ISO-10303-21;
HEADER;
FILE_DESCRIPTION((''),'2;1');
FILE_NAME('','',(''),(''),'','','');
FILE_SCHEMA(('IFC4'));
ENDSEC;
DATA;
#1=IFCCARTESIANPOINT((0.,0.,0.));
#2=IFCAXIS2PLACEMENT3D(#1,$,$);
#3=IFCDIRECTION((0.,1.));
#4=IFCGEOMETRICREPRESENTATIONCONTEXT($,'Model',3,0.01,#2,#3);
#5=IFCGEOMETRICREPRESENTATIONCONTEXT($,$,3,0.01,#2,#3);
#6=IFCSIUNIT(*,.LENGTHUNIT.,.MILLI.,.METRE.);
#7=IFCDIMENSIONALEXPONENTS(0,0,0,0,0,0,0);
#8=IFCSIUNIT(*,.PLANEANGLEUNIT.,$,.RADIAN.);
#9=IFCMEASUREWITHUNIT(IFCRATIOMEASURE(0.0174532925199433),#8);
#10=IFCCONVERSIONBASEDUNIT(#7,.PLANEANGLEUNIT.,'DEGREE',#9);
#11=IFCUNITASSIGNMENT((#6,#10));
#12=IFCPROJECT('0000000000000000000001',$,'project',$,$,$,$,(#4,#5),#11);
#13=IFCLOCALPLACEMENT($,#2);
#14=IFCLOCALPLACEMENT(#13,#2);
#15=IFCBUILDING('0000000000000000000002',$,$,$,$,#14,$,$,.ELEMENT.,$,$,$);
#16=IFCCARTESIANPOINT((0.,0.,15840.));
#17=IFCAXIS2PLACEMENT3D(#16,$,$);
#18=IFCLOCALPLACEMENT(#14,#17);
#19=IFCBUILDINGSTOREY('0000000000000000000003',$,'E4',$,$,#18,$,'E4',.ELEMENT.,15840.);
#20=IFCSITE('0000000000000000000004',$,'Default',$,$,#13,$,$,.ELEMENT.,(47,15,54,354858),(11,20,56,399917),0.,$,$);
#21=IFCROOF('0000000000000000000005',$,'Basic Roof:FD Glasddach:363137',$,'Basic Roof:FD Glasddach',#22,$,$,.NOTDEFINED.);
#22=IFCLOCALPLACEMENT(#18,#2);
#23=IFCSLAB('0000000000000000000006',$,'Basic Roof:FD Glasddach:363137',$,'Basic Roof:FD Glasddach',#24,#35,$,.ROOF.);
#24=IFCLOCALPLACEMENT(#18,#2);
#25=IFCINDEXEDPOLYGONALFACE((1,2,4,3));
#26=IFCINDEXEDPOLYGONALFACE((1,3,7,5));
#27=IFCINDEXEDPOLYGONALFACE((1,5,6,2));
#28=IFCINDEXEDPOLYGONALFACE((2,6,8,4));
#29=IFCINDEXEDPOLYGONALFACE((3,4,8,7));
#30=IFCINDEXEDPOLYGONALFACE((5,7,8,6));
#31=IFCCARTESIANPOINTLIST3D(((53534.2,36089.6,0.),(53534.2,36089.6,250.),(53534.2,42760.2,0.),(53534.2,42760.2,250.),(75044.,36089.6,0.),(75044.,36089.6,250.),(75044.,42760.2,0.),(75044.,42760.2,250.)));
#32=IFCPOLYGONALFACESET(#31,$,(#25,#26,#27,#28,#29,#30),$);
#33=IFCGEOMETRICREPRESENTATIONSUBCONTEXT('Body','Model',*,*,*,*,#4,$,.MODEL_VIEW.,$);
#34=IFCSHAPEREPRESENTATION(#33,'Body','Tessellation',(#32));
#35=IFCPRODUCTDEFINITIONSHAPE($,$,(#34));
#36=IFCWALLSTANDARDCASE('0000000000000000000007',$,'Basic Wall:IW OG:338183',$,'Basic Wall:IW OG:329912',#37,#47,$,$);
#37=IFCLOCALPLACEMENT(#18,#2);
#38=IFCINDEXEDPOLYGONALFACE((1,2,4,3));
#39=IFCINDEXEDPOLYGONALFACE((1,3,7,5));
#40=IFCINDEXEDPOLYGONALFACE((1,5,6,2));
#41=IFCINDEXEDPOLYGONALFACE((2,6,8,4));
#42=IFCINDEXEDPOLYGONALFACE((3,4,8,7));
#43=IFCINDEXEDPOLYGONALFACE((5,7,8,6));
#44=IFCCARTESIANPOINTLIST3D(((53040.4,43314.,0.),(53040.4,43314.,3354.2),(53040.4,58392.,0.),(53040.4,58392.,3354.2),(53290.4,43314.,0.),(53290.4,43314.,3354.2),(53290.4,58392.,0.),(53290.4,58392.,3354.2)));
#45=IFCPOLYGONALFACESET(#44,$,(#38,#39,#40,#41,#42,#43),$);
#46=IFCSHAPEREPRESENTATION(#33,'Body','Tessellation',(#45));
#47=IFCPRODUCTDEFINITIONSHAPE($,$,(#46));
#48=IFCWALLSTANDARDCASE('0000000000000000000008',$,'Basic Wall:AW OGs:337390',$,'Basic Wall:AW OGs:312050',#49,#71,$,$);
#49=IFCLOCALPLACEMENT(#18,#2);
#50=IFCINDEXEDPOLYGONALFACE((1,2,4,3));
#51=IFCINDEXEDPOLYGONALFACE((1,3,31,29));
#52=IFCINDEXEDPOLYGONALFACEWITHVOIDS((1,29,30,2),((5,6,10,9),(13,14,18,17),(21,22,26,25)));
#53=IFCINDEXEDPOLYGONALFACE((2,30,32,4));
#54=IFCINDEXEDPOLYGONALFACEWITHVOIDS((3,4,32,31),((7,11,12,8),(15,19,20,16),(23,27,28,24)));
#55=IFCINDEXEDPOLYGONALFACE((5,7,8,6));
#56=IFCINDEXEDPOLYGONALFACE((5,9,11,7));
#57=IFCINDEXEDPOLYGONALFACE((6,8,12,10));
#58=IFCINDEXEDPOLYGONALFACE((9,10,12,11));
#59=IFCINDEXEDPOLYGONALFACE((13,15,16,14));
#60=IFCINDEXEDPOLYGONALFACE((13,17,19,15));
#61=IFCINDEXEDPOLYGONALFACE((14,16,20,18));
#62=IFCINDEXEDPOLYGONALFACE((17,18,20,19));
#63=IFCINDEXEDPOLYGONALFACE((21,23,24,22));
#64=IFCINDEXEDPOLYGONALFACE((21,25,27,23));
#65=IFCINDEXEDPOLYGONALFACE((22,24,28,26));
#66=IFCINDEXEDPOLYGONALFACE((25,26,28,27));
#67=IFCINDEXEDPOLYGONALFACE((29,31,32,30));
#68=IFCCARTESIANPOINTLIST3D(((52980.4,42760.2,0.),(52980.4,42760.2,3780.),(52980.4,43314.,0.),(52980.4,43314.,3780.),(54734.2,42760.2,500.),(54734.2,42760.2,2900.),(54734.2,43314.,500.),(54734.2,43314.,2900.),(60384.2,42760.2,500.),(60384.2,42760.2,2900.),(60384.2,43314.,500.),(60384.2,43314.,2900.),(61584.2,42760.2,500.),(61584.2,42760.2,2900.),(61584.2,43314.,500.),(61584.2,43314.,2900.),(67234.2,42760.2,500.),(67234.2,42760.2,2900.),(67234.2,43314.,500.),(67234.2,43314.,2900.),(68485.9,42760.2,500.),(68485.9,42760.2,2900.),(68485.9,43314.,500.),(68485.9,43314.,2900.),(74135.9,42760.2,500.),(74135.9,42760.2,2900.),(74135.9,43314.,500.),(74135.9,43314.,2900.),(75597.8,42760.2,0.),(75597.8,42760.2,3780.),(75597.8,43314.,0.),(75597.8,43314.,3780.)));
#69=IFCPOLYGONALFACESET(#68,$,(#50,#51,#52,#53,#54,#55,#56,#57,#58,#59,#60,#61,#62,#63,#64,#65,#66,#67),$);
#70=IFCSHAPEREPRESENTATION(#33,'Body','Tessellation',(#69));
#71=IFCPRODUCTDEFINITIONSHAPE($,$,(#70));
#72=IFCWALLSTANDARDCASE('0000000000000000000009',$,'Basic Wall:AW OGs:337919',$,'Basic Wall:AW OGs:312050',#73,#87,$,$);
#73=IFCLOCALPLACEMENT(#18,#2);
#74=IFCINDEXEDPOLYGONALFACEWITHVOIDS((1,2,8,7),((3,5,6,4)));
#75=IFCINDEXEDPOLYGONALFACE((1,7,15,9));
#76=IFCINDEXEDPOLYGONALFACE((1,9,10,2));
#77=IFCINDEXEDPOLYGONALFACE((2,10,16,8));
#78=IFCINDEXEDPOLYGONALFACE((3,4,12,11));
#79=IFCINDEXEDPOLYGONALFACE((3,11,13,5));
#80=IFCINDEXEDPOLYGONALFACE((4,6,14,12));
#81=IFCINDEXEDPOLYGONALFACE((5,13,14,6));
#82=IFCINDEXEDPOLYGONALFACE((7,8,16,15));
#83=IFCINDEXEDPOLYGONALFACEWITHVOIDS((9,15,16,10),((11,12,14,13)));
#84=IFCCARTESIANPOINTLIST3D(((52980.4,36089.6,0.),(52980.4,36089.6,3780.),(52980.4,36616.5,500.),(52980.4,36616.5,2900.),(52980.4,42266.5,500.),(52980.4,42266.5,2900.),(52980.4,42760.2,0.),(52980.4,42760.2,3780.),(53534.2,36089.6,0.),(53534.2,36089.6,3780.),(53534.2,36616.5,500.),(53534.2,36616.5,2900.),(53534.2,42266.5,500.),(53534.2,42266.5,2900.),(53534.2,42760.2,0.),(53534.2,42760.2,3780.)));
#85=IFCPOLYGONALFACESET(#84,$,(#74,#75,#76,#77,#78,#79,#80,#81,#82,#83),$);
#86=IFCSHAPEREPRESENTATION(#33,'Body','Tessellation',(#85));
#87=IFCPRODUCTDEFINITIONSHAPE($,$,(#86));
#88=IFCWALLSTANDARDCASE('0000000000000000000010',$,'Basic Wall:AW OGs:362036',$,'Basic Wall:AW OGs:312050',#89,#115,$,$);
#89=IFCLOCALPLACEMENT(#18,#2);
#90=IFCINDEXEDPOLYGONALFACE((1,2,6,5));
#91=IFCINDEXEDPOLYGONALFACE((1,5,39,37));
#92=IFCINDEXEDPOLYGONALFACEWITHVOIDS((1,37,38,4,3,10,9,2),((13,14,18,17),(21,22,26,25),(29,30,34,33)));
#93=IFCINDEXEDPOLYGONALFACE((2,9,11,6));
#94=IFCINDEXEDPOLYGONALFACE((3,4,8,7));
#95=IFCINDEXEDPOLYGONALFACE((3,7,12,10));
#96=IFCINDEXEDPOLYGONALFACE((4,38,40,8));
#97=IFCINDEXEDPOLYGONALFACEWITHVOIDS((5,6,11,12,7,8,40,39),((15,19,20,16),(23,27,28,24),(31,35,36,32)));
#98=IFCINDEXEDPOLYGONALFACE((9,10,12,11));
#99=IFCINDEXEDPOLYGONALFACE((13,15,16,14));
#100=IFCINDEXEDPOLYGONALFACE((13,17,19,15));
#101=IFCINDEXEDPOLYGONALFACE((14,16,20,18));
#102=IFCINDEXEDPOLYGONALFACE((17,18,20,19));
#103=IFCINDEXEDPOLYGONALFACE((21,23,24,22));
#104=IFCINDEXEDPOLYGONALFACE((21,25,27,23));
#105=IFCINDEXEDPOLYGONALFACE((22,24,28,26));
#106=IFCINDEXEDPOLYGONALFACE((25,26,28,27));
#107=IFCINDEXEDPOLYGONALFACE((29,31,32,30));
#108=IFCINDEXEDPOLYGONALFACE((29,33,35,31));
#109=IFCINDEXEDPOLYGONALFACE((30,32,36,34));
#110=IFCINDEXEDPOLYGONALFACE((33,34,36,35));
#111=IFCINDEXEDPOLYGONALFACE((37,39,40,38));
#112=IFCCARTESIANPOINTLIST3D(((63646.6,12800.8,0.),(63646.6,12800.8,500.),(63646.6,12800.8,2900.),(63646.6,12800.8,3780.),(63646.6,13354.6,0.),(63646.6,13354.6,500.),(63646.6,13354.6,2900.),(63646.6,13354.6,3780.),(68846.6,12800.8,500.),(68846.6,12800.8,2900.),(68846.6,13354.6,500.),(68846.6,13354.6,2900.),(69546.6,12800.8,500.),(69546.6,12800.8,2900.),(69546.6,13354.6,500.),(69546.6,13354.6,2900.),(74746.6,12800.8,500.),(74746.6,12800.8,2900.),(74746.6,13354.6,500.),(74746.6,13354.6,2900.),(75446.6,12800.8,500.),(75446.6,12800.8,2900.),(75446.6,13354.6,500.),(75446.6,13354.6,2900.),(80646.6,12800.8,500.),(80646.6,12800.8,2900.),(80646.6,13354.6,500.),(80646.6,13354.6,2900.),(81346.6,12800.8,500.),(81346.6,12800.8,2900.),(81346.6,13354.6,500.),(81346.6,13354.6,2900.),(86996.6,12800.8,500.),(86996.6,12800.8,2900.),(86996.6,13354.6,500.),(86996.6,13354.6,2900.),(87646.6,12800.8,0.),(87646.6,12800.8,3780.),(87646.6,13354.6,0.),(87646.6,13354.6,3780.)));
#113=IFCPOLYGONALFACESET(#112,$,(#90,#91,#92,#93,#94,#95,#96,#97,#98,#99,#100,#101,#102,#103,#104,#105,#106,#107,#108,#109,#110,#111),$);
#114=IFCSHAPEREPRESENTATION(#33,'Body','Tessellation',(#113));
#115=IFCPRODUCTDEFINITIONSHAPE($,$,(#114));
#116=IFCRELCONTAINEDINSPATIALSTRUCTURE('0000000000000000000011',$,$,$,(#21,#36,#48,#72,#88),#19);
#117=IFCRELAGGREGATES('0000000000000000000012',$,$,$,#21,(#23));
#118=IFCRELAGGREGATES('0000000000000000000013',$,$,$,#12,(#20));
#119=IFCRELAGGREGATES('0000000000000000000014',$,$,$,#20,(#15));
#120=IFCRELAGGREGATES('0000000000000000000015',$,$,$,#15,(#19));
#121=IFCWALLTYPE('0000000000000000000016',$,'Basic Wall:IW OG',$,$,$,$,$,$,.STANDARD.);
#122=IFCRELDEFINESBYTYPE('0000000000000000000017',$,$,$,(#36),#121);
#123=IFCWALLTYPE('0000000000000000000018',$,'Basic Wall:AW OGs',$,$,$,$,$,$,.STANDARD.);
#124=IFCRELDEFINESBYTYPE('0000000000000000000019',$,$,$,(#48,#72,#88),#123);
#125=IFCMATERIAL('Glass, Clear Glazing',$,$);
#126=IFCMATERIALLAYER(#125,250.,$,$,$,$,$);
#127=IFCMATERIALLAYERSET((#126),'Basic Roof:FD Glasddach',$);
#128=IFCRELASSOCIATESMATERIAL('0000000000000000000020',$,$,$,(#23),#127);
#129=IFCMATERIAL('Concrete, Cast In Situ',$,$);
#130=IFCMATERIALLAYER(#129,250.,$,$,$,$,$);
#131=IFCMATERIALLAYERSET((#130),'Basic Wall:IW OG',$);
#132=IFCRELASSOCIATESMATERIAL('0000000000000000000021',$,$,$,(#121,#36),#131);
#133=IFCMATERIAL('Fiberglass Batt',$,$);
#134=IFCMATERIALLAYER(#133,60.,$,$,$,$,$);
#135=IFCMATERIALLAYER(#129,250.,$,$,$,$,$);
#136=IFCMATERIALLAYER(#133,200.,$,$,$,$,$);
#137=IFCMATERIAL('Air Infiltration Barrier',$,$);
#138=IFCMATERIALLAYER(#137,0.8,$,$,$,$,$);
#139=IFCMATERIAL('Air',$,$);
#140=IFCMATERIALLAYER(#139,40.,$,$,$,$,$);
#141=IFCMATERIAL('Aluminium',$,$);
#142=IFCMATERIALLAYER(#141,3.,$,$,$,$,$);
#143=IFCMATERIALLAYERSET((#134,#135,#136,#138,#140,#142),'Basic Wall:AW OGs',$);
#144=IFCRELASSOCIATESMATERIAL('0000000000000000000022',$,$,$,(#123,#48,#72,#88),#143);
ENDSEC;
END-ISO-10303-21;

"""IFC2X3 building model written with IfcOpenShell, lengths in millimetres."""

from ifc_helpers import new_model, entity, si_unit, converted_unit, direction, frame, frame_2d, origin, place, context, subcontext, project, spatial, polyline, rectangle, extrude, clip, bounded_halfspace, material, layer, layer_set, layer_usage, type_object, element, aggregate, save


model = new_model("IFC2X3")

# Units and contexts
model_context = context("Model", 3, precision=0.01, world=origin(), true_north=direction((0.0, 1.0)))
context_of_model = context(None, 3, precision=0.01, world=origin(), true_north=direction((0.0, 1.0)))
body_context = subcontext(model_context, "Body", "Model", "MODEL_VIEW")
ifc_project = project(units=[si_unit("LENGTHUNIT", "METRE", prefix="MILLI"), converted_unit("PLANEANGLEUNIT", "DEGREE", entity("IfcRatioMeasure", 0.0174532925199433), si_unit("PLANEANGLEUNIT", "RADIAN"), dimensions=[0, 0, 0, 0, 0, 0, 0])], contexts=[model_context, context_of_model])

# Site, building, storey
site_placement = place(None, origin())
site = spatial("IfcSite", under=ifc_project, at=site_placement, Name="Default", CompositionType="ELEMENT", RefLatitude=(47, 15, 54, 354858), RefLongitude=(11, 20, 56, 399917), RefElevation=0.0)
building_placement = place(site_placement, origin())
building = spatial("IfcBuilding", under=site, at=building_placement, CompositionType="ELEMENT")
storey_placement = place(building_placement, frame((0.0, 0.0, 15840.0)))
storey = spatial("IfcBuildingStorey", under=building, at=storey_placement, Name="E4", LongName="E4", CompositionType="ELEMENT", Elevation=15840.0)

# Roof, slab
roof_placement = place(storey_placement, frame((53534.2, 36089.6, 0.0)))
roof = element("IfcRoof", 1, at=roof_placement, inside=storey, Name="Basic Roof:FD Glasddach:363137", ObjectType="Basic Roof:FD Glasddach", ShapeType="NOTDEFINED")
ifc_material_1 = material(Name="Glass, Clear Glazing")
ifc_layer_1 = layer(ifc_material_1, 250.0)
ifc_layer_set_1 = layer_set([ifc_layer_1], Name="Basic Roof:FD Glasddach")
slab_placement = place(roof_placement, origin())
slab = element("IfcSlab", 2, at=slab_placement, material=ifc_layer_set_1, Name="Basic Roof:FD Glasddach:363137", ObjectType="Basic Roof:FD Glasddach", PredefinedType="ROOF", context=body_context, shape_type="SweptSolid", body=[
    extrude(rectangle(XDim=21509.8, YDim=6670.6, at=frame_2d((0.0, 0.0), x_axis=(1.0, 0.0))), frame((10754.9, 3335.3, 0.0)), (0.0, 0.0, 1.0), 250.0),
])
aggregate(roof, [slab])

# Wall
ifc_material_2 = material(Name="Concrete, Cast In Situ")
ifc_layer_2 = layer(ifc_material_2, 250.0)
ifc_layer_set_2 = layer_set([ifc_layer_2], Name="Basic Wall:IW OG")
ifc_layer_usage_1 = layer_usage(ifc_layer_set_2, "AXIS2", "POSITIVE", -125.0)
wall_type_1 = type_object("IfcWallType", Name="Basic Wall:IW OG", PredefinedType="STANDARD", material=ifc_layer_set_2)
wall_1_placement = place(storey_placement, frame((53165.4, 43314.0, 0.0), z_axis=(0.0, 0.0, 1.0), x_axis=(0.0, 1.0, 0.0)))
element("IfcWallStandardCase", 3, at=wall_1_placement, inside=storey, type_object=wall_type_1, material=ifc_layer_usage_1, Name="Basic Wall:IW OG:338183", ObjectType="Basic Wall:IW OG:329912", context=body_context, shape_type="Clipping", body=[
    clip(extrude(rectangle(XDim=15078.0, YDim=250.0, at=frame_2d((7539.0, 0.0), x_axis=(-1.0, 0.0))), origin(), (0.0, 0.0, 1.0), 3354.2), bounded_halfspace(frame((0.0, -125.0, 3354.2), z_axis=(0.0, 0.0, -1.0), x_axis=(0.0, -1.0, 0.0)), True, frame((0.0, -125.0, 3354.2)), polyline([(0.0, 0.0), (15078.0, 0.0), (15078.0, 250.0), (0.0, 250.0), (0.0, 0.0)]))),
])

# Wall, openings
ifc_material_3 = material(Name="Fiberglass Batt")
ifc_layer_3 = layer(ifc_material_3, 60.0)
ifc_layer_4 = layer(ifc_material_2, 250.0)
ifc_layer_5 = layer(ifc_material_3, 200.0)
ifc_material_4 = material(Name="Air Infiltration Barrier")
ifc_layer_6 = layer(ifc_material_4, 0.8)
ifc_material_5 = material(Name="Air")
ifc_layer_7 = layer(ifc_material_5, 40.0)
ifc_material_6 = material(Name="Aluminium")
ifc_layer_8 = layer(ifc_material_6, 3.0)
ifc_layer_set_3 = layer_set([ifc_layer_3, ifc_layer_4, ifc_layer_5, ifc_layer_6, ifc_layer_7, ifc_layer_8], Name="Basic Wall:AW OGs")
ifc_layer_usage_2 = layer_usage(ifc_layer_set_3, "AXIS2", "NEGATIVE", 276.9)
wall_type_2 = type_object("IfcWallType", Name="Basic Wall:AW OGs", PredefinedType="STANDARD", material=ifc_layer_set_3)
wall_2_placement = place(storey_placement, frame((52980.4, 43037.1, 0.0)))
wall_2 = element("IfcWallStandardCase", 4, at=wall_2_placement, inside=storey, type_object=wall_type_2, material=ifc_layer_usage_2, Name="Basic Wall:AW OGs:337390", ObjectType="Basic Wall:AW OGs:312050", context=body_context, shape_type="SweptSolid", body=[
    extrude(rectangle(XDim=22617.4, YDim=553.8, at=frame_2d((11308.7, 0.0), x_axis=(-1.0, 0.0))), origin(), (0.0, 0.0, 1.0), 3780.0),
])
opening_1_placement = place(wall_2_placement, frame((21155.6, 276.9, 500.0)))
element("IfcOpeningElement", 5, at=opening_1_placement, cuts=wall_2, ObjectType="Opening", context=body_context, shape_type="SweptSolid", body=[
    extrude(rectangle(XDim=2400.0, YDim=5650.0, at=frame_2d((1200.0, 2825.0), x_axis=(-1.0, 0.0))), frame((0.0, 0.0, 0.0), z_axis=(0.0, -1.0, 0.0), x_axis=(0.0, 0.0, 1.0)), (0.0, 0.0, 1.0), 553.8),
])
opening_2_placement = place(wall_2_placement, frame((14253.8, 276.9, 500.0)))
element("IfcOpeningElement", 6, at=opening_2_placement, cuts=wall_2, ObjectType="Opening", context=body_context, shape_type="SweptSolid", body=[
    extrude(rectangle(XDim=2400.0, YDim=5650.0, at=frame_2d((1200.0, 2825.0), x_axis=(-1.0, 0.0))), frame((0.0, 0.0, 0.0), z_axis=(0.0, -1.0, 0.0), x_axis=(0.0, 0.0, 1.0)), (0.0, 0.0, 1.0), 553.8),
])
opening_3_placement = place(wall_2_placement, frame((7403.8, 276.9, 500.0)))
element("IfcOpeningElement", 7, at=opening_3_placement, cuts=wall_2, ObjectType="Opening", context=body_context, shape_type="SweptSolid", body=[
    extrude(rectangle(XDim=2400.0, YDim=5650.0, at=frame_2d((1200.0, 2825.0), x_axis=(-1.0, 0.0))), frame((0.0, 0.0, 0.0), z_axis=(0.0, -1.0, 0.0), x_axis=(0.0, 0.0, 1.0)), (0.0, 0.0, 1.0), 553.8),
])

# Wall, opening
ifc_layer_usage_3 = layer_usage(ifc_layer_set_3, "AXIS2", "NEGATIVE", 276.9)
wall_3_placement = place(storey_placement, frame((53257.3, 36089.6, 0.0), z_axis=(0.0, 0.0, 1.0), x_axis=(0.0, 1.0, 0.0)))
wall_3 = element("IfcWallStandardCase", 8, at=wall_3_placement, inside=storey, type_object=wall_type_2, material=ifc_layer_usage_3, Name="Basic Wall:AW OGs:337919", ObjectType="Basic Wall:AW OGs:312050", context=body_context, shape_type="SweptSolid", body=[
    extrude(rectangle(XDim=6670.6, YDim=553.8, at=frame_2d((3335.3, 0.0), x_axis=(-1.0, 0.0))), origin(), (0.0, 0.0, 1.0), 3780.0),
])
opening_4_placement = place(wall_3_placement, frame((6176.8, 276.9, 500.0)))
element("IfcOpeningElement", 9, at=opening_4_placement, cuts=wall_3, ObjectType="Opening", context=body_context, shape_type="SweptSolid", body=[
    extrude(rectangle(XDim=2400.0, YDim=5650.0, at=frame_2d((1200.0, 2825.0), x_axis=(-1.0, 0.0))), frame((0.0, 0.0, 0.0), z_axis=(0.0, -1.0, 0.0), x_axis=(0.0, 0.0, 1.0)), (0.0, 0.0, 1.0), 553.8),
])

# Wall, openings
ifc_layer_usage_4 = layer_usage(ifc_layer_set_3, "AXIS2", "NEGATIVE", 276.9)
wall_4_placement = place(storey_placement, frame((63646.6, 13077.7, 0.0)))
wall_4 = element("IfcWallStandardCase", 10, at=wall_4_placement, inside=storey, type_object=wall_type_2, material=ifc_layer_usage_4, Name="Basic Wall:AW OGs:362036", ObjectType="Basic Wall:AW OGs:312050", context=body_context, shape_type="SweptSolid", body=[
    extrude(rectangle(XDim=24000.0, YDim=553.8, at=frame_2d((12000.0, 0.0), x_axis=(-1.0, 0.0))), origin(), (0.0, 0.0, 1.0), 3780.0),
])
opening_5_placement = place(wall_4_placement, frame((5200.0, 276.9, 500.0)))
element("IfcOpeningElement", 11, at=opening_5_placement, cuts=wall_4, ObjectType="Opening", context=body_context, shape_type="SweptSolid", body=[
    extrude(rectangle(XDim=2400.0, YDim=5200.0, at=frame_2d((1200.0, 2600.0), x_axis=(-1.0, 0.0))), frame((0.0, 0.0, 0.0), z_axis=(0.0, -1.0, 0.0), x_axis=(0.0, 0.0, 1.0)), (0.0, 0.0, 1.0), 553.8),
])
opening_6_placement = place(wall_4_placement, frame((17000.0, 276.9, 500.0)))
element("IfcOpeningElement", 12, at=opening_6_placement, cuts=wall_4, ObjectType="Opening", context=body_context, shape_type="SweptSolid", body=[
    extrude(rectangle(XDim=2400.0, YDim=5200.0, at=frame_2d((1200.0, 2600.0), x_axis=(-1.0, 0.0))), frame((0.0, 0.0, 0.0), z_axis=(0.0, -1.0, 0.0), x_axis=(0.0, 0.0, 1.0)), (0.0, 0.0, 1.0), 553.8),
])
opening_7_placement = place(wall_4_placement, frame((23350.0, 276.9, 500.0)))
element("IfcOpeningElement", 13, at=opening_7_placement, cuts=wall_4, ObjectType="Opening", context=body_context, shape_type="SweptSolid", body=[
    extrude(rectangle(XDim=2400.0, YDim=5650.0, at=frame_2d((1200.0, 2825.0), x_axis=(-1.0, 0.0))), frame((0.0, 0.0, 0.0), z_axis=(0.0, -1.0, 0.0), x_axis=(0.0, 0.0, 1.0)), (0.0, 0.0, 1.0), 553.8),
])
opening_8_placement = place(wall_4_placement, frame((11100.0, 276.9, 500.0)))
element("IfcOpeningElement", 14, at=opening_8_placement, cuts=wall_4, ObjectType="Opening", context=body_context, shape_type="SweptSolid", body=[
    extrude(rectangle(XDim=2400.0, YDim=5200.0, at=frame_2d((1200.0, 2600.0), x_axis=(-1.0, 0.0))), frame((0.0, 0.0, 0.0), z_axis=(0.0, -1.0, 0.0), x_axis=(0.0, 0.0, 1.0)), (0.0, 0.0, 1.0), 553.8),
])

save(model, "model.ifc")
